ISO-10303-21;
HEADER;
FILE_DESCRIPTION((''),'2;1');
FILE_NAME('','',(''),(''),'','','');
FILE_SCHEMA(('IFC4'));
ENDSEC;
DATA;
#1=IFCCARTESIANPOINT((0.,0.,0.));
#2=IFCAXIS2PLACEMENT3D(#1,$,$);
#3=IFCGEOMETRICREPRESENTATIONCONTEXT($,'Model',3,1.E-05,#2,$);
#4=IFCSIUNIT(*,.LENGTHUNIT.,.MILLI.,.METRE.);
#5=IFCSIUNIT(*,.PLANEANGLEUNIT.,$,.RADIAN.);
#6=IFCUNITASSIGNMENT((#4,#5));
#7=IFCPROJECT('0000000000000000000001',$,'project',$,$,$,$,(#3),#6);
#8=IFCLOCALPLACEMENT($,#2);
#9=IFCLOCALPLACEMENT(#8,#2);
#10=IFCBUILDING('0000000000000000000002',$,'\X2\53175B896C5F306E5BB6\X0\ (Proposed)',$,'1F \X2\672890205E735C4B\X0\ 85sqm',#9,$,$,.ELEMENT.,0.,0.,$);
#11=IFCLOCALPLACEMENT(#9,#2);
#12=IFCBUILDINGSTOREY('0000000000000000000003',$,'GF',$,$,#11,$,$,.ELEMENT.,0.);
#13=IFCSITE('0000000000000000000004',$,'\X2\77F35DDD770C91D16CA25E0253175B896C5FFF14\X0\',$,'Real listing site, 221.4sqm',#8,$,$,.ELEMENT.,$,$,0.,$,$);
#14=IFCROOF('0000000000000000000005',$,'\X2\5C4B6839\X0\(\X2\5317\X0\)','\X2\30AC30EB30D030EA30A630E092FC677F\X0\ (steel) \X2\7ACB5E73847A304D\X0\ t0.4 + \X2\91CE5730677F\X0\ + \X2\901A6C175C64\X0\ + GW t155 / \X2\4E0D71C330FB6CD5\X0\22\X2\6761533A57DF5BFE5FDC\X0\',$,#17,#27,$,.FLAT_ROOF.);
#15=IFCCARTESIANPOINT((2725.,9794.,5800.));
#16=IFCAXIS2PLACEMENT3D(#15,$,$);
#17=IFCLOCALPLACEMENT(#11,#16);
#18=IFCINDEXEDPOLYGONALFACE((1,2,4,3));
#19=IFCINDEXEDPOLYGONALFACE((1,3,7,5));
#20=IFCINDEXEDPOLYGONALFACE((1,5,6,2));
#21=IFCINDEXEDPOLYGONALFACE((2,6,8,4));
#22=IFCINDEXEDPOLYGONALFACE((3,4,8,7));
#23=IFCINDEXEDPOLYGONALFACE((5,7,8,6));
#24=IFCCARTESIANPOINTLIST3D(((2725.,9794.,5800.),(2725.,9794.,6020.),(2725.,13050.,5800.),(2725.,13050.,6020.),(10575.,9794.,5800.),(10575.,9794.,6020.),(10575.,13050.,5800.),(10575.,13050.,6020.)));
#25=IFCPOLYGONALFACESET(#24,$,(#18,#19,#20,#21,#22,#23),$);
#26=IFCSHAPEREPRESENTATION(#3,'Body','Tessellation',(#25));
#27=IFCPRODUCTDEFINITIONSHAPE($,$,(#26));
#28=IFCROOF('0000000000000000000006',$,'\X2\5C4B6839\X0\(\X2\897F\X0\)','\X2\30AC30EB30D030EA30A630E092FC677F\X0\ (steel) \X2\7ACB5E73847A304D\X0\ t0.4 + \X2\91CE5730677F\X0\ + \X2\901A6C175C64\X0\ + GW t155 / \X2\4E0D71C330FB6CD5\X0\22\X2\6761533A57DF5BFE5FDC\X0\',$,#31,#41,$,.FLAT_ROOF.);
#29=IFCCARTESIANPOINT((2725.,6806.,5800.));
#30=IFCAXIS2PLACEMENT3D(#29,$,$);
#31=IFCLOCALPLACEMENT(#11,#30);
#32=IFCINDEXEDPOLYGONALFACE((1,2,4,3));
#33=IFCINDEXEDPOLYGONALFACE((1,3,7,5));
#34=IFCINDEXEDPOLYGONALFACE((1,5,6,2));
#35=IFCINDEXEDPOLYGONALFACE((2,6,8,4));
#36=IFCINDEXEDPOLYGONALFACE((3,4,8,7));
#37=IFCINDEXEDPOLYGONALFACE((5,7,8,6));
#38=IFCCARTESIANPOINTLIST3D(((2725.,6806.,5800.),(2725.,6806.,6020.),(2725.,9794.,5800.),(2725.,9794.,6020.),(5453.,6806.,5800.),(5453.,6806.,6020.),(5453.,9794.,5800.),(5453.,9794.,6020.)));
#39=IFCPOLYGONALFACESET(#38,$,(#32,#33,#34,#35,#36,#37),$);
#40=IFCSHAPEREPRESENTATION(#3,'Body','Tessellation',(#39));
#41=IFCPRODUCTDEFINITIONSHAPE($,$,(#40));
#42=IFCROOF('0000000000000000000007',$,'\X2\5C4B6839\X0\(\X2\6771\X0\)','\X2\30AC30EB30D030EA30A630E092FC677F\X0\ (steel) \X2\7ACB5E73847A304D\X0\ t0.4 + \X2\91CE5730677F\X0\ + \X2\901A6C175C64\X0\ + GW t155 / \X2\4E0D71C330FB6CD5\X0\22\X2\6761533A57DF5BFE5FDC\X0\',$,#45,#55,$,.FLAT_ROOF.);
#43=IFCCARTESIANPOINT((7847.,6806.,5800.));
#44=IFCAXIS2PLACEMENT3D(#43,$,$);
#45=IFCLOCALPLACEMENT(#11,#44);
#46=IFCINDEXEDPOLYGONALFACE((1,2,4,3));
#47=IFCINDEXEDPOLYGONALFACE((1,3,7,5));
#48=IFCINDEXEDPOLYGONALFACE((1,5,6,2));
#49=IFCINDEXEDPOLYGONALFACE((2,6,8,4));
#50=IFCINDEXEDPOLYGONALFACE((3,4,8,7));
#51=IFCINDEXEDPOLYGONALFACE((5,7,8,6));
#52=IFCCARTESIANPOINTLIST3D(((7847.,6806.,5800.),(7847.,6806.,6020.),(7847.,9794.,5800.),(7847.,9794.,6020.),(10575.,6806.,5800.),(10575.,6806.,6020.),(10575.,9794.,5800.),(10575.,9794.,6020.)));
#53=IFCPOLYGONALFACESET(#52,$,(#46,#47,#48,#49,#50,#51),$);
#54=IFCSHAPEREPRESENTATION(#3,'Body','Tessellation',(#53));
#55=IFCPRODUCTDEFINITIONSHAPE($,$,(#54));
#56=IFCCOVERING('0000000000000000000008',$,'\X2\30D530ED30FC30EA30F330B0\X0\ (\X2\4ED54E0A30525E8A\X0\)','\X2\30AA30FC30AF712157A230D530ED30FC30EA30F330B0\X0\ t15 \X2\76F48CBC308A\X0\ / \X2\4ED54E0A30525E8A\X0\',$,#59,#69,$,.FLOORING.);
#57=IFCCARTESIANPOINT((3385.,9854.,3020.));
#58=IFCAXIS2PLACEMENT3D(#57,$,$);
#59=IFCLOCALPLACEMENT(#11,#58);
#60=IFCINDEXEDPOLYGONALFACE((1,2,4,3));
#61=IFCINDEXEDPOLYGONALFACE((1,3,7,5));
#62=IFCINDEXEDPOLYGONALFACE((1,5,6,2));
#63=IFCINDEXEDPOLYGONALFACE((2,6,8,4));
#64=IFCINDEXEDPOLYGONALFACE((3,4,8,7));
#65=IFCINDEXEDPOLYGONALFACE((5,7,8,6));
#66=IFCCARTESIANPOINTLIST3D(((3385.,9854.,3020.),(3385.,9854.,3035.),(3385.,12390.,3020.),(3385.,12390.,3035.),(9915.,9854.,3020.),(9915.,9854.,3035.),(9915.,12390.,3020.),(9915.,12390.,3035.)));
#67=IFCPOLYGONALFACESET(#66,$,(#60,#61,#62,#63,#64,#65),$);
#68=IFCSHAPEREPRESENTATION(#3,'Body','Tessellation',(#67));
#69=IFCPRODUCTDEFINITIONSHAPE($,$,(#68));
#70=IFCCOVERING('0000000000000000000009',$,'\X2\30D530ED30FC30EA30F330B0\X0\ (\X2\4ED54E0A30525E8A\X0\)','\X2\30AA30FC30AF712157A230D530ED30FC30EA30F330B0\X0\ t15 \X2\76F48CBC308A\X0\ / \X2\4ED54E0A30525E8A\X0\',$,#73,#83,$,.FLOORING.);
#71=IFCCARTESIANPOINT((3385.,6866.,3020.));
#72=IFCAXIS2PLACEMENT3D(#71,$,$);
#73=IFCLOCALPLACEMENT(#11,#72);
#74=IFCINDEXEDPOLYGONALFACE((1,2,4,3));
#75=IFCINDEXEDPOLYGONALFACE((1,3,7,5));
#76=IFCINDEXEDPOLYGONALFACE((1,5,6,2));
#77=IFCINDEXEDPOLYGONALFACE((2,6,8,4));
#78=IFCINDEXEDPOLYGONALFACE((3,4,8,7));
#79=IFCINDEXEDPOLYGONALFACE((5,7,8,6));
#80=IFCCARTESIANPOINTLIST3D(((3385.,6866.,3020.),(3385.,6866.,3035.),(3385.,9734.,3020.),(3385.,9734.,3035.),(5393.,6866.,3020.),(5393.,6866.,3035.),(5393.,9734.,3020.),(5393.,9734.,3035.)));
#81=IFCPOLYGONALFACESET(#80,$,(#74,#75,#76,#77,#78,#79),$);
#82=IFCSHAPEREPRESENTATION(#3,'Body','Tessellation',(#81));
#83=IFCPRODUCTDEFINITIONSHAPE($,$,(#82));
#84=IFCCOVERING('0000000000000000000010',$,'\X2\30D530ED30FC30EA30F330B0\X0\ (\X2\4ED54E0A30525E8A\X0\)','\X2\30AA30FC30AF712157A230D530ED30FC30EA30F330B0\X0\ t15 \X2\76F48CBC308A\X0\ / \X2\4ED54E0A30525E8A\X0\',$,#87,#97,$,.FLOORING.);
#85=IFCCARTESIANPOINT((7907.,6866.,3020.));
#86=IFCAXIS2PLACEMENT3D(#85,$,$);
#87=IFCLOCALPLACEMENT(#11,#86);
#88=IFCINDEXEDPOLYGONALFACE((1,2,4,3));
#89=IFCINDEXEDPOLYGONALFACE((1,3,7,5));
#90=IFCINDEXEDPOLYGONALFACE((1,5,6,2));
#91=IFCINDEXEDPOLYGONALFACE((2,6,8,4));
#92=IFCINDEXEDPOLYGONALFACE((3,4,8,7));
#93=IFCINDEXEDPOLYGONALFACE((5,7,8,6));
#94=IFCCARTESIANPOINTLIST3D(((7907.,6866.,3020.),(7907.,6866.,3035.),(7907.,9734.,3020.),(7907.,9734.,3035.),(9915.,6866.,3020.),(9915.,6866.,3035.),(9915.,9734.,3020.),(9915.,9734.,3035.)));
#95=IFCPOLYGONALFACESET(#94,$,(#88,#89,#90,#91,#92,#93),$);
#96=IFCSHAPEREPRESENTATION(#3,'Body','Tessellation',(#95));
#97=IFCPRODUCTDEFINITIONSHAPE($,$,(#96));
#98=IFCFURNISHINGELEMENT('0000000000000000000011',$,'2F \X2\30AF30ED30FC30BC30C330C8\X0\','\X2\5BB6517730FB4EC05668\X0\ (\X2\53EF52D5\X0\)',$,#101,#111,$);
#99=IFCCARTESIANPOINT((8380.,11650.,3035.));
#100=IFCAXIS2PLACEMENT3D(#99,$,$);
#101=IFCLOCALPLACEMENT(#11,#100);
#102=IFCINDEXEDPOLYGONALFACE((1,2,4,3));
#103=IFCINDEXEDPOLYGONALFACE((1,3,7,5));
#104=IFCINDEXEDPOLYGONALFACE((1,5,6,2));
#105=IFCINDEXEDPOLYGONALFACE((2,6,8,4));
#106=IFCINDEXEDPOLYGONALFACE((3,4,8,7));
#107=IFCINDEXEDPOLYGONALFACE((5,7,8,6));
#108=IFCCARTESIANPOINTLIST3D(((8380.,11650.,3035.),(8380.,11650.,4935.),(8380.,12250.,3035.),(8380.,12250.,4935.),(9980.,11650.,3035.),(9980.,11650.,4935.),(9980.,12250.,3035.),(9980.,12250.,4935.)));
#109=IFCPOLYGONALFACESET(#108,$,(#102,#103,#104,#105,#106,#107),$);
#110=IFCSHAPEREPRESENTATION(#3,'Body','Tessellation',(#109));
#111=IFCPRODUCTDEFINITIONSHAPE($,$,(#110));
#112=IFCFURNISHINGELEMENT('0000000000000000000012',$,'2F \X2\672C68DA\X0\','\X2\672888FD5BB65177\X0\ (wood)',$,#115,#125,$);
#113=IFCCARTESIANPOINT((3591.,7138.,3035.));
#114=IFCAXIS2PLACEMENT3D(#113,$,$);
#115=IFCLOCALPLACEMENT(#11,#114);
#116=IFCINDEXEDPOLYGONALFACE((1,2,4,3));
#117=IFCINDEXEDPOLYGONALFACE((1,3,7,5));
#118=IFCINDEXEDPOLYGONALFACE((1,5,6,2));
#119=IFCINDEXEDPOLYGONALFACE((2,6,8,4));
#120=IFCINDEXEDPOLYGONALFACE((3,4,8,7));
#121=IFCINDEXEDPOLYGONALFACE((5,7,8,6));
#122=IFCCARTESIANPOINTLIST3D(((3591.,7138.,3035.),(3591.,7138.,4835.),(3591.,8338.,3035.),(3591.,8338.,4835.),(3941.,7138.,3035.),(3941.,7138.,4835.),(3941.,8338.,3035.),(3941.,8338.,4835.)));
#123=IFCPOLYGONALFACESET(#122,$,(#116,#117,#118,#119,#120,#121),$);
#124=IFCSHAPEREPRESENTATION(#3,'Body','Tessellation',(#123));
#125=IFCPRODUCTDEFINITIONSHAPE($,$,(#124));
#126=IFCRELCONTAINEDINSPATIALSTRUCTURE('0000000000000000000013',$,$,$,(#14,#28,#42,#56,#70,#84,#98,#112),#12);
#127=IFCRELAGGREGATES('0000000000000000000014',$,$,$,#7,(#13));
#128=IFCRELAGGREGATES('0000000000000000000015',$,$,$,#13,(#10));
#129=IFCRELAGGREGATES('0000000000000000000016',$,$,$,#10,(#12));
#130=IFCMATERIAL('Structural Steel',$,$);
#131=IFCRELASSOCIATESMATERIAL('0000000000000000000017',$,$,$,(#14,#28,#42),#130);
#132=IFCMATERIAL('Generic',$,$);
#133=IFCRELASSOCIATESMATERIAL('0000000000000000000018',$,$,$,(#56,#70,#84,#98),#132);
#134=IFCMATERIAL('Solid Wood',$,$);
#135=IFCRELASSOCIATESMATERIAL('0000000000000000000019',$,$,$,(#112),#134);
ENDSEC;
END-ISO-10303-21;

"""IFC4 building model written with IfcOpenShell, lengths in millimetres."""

from ifc_helpers import new_model, si_unit, frame, frame_2d, origin, place, context, project, spatial, rectangle, extrude, material, element, save


model = new_model("IFC4")

# Units and contexts
model_context = context("Model", 3, precision=1e-05, world=origin())
ifc_project = project(units=[si_unit("LENGTHUNIT", "METRE", prefix="MILLI"), si_unit("PLANEANGLEUNIT", "RADIAN")], contexts=[model_context])

# Site, building, storey
site_placement = place(None, origin())
site = spatial("IfcSite", under=ifc_project, at=site_placement, Name="石川県金沢市北安江４", ObjectType="Real listing site, 221.4sqm", CompositionType="ELEMENT", RefElevation=0.0)
building_placement = place(site_placement, origin())
building = spatial("IfcBuilding", under=site, at=building_placement, Name="北安江の家 (Proposed)", ObjectType="1F 木造平屋 85sqm", CompositionType="ELEMENT", ElevationOfRefHeight=0.0, ElevationOfTerrain=0.0)
storey_placement = place(building_placement, origin())
storey = spatial("IfcBuildingStorey", under=building, at=storey_placement, Name="GF", CompositionType="ELEMENT", Elevation=0.0)

# Shared definitions
ifc_material_1 = material(Name="Solid Wood")

# Shared definitions
ifc_material_2 = material(Name="Generic")

# Roofs
ifc_material_3 = material(Name="Structural Steel")
for number, where, name in (
    (1, (2725.0, 9794.0, 5800.0), "屋根(北)"),
):
    element("IfcRoof", number, at=place(storey_placement, frame(where)), inside=storey, material=ifc_material_3, Name=name, Description="ガルバリウム鋼板 (steel) 立平葺き t0.4 + 野地板 + 通気層 + GW t155 / 不燃・法22条区域対応", PredefinedType="FLAT_ROOF", context=model_context, shape_type="SweptSolid", body=[
        extrude(rectangle(XDim=7850.0, YDim=3256.0, at=frame_2d((3925.0, 1628.0))), frame((2725.0, 9794.0, 5800.0)), (0.0, 0.0, 1.0), 220.0),
    ])
roof_1_placement = place(storey_placement, frame((2725.0, 6806.0, 5800.0)))
element("IfcRoof", 2, at=roof_1_placement, inside=storey, material=ifc_material_3, Name="屋根(西)", Description="ガルバリウム鋼板 (steel) 立平葺き t0.4 + 野地板 + 通気層 + GW t155 / 不燃・法22条区域対応", PredefinedType="FLAT_ROOF", context=model_context, shape_type="SweptSolid", body=[
    extrude(rectangle(XDim=2728.0, YDim=2988.0, at=frame_2d((1364.0, 1494.0))), frame((2725.0, 6806.0, 5800.0)), (0.0, 0.0, 1.0), 220.0),
])
roof_2_placement = place(storey_placement, frame((7847.0, 6806.0, 5800.0)))
element("IfcRoof", 3, at=roof_2_placement, inside=storey, material=ifc_material_3, Name="屋根(東)", Description="ガルバリウム鋼板 (steel) 立平葺き t0.4 + 野地板 + 通気層 + GW t155 / 不燃・法22条区域対応", PredefinedType="FLAT_ROOF", context=model_context, shape_type="SweptSolid", body=[
    extrude(rectangle(XDim=2728.0, YDim=2988.0, at=frame_2d((1364.0, 1494.0))), frame((7847.0, 6806.0, 5800.0)), (0.0, 0.0, 1.0), 220.0),
])

# Coverings
covering_1_placement = place(storey_placement, frame((3385.0, 9854.0, 3020.0)))
element("IfcCovering", 4, at=covering_1_placement, inside=storey, material=ifc_material_2, Name="フローリング (仕上げ床)", Description="オーク無垢フローリング t15 直貼り / 仕上げ床", PredefinedType="FLOORING", context=model_context, shape_type="SweptSolid", body=[
    extrude(rectangle(XDim=6530.0, YDim=2536.0, at=frame_2d((3265.0, 1268.0))), frame((3385.0, 9854.0, 3020.0)), (0.0, 0.0, 1.0), 15.0),
])
covering_2_placement = place(storey_placement, frame((3385.0, 6866.0, 3020.0)))
element("IfcCovering", 5, at=covering_2_placement, inside=storey, material=ifc_material_2, Name="フローリング (仕上げ床)", Description="オーク無垢フローリング t15 直貼り / 仕上げ床", PredefinedType="FLOORING", context=model_context, shape_type="SweptSolid", body=[
    extrude(rectangle(XDim=2008.0, YDim=2868.0, at=frame_2d((1004.0, 1434.0))), frame((3385.0, 6866.0, 3020.0)), (0.0, 0.0, 1.0), 15.0),
])
covering_3_placement = place(storey_placement, frame((7907.0, 6866.0, 3020.0)))
element("IfcCovering", 6, at=covering_3_placement, inside=storey, material=ifc_material_2, Name="フローリング (仕上げ床)", Description="オーク無垢フローリング t15 直貼り / 仕上げ床", PredefinedType="FLOORING", context=model_context, shape_type="SweptSolid", body=[
    extrude(rectangle(XDim=2008.0, YDim=2868.0, at=frame_2d((1004.0, 1434.0))), frame((7907.0, 6866.0, 3020.0)), (0.0, 0.0, 1.0), 15.0),
])

# Furnishing elements
furnishing_1_placement = place(storey_placement, frame((8380.0, 11650.0, 3035.0)))
element("IfcFurnishingElement", 7, at=furnishing_1_placement, inside=storey, material=ifc_material_2, Name="2F クローゼット", Description="家具・什器 (可動)", context=model_context, shape_type="SweptSolid", body=[
    extrude(rectangle(XDim=1600.0, YDim=600.0, at=frame_2d((800.0, 300.0))), frame((8380.0, 11650.0, 3035.0)), (0.0, 0.0, 1.0), 1900.0),
])
furnishing_2_placement = place(storey_placement, frame((3591.0, 7138.0, 3035.0)))
element("IfcFurnishingElement", 8, at=furnishing_2_placement, inside=storey, material=ifc_material_1, Name="2F 本棚", Description="木製家具 (wood)", context=model_context, shape_type="SweptSolid", body=[
    extrude(rectangle(XDim=350.0, YDim=1200.0, at=frame_2d((175.0, 600.0))), frame((3591.0, 7138.0, 3035.0)), (0.0, 0.0, 1.0), 1800.0),
])

save(model, "model.ifc")
